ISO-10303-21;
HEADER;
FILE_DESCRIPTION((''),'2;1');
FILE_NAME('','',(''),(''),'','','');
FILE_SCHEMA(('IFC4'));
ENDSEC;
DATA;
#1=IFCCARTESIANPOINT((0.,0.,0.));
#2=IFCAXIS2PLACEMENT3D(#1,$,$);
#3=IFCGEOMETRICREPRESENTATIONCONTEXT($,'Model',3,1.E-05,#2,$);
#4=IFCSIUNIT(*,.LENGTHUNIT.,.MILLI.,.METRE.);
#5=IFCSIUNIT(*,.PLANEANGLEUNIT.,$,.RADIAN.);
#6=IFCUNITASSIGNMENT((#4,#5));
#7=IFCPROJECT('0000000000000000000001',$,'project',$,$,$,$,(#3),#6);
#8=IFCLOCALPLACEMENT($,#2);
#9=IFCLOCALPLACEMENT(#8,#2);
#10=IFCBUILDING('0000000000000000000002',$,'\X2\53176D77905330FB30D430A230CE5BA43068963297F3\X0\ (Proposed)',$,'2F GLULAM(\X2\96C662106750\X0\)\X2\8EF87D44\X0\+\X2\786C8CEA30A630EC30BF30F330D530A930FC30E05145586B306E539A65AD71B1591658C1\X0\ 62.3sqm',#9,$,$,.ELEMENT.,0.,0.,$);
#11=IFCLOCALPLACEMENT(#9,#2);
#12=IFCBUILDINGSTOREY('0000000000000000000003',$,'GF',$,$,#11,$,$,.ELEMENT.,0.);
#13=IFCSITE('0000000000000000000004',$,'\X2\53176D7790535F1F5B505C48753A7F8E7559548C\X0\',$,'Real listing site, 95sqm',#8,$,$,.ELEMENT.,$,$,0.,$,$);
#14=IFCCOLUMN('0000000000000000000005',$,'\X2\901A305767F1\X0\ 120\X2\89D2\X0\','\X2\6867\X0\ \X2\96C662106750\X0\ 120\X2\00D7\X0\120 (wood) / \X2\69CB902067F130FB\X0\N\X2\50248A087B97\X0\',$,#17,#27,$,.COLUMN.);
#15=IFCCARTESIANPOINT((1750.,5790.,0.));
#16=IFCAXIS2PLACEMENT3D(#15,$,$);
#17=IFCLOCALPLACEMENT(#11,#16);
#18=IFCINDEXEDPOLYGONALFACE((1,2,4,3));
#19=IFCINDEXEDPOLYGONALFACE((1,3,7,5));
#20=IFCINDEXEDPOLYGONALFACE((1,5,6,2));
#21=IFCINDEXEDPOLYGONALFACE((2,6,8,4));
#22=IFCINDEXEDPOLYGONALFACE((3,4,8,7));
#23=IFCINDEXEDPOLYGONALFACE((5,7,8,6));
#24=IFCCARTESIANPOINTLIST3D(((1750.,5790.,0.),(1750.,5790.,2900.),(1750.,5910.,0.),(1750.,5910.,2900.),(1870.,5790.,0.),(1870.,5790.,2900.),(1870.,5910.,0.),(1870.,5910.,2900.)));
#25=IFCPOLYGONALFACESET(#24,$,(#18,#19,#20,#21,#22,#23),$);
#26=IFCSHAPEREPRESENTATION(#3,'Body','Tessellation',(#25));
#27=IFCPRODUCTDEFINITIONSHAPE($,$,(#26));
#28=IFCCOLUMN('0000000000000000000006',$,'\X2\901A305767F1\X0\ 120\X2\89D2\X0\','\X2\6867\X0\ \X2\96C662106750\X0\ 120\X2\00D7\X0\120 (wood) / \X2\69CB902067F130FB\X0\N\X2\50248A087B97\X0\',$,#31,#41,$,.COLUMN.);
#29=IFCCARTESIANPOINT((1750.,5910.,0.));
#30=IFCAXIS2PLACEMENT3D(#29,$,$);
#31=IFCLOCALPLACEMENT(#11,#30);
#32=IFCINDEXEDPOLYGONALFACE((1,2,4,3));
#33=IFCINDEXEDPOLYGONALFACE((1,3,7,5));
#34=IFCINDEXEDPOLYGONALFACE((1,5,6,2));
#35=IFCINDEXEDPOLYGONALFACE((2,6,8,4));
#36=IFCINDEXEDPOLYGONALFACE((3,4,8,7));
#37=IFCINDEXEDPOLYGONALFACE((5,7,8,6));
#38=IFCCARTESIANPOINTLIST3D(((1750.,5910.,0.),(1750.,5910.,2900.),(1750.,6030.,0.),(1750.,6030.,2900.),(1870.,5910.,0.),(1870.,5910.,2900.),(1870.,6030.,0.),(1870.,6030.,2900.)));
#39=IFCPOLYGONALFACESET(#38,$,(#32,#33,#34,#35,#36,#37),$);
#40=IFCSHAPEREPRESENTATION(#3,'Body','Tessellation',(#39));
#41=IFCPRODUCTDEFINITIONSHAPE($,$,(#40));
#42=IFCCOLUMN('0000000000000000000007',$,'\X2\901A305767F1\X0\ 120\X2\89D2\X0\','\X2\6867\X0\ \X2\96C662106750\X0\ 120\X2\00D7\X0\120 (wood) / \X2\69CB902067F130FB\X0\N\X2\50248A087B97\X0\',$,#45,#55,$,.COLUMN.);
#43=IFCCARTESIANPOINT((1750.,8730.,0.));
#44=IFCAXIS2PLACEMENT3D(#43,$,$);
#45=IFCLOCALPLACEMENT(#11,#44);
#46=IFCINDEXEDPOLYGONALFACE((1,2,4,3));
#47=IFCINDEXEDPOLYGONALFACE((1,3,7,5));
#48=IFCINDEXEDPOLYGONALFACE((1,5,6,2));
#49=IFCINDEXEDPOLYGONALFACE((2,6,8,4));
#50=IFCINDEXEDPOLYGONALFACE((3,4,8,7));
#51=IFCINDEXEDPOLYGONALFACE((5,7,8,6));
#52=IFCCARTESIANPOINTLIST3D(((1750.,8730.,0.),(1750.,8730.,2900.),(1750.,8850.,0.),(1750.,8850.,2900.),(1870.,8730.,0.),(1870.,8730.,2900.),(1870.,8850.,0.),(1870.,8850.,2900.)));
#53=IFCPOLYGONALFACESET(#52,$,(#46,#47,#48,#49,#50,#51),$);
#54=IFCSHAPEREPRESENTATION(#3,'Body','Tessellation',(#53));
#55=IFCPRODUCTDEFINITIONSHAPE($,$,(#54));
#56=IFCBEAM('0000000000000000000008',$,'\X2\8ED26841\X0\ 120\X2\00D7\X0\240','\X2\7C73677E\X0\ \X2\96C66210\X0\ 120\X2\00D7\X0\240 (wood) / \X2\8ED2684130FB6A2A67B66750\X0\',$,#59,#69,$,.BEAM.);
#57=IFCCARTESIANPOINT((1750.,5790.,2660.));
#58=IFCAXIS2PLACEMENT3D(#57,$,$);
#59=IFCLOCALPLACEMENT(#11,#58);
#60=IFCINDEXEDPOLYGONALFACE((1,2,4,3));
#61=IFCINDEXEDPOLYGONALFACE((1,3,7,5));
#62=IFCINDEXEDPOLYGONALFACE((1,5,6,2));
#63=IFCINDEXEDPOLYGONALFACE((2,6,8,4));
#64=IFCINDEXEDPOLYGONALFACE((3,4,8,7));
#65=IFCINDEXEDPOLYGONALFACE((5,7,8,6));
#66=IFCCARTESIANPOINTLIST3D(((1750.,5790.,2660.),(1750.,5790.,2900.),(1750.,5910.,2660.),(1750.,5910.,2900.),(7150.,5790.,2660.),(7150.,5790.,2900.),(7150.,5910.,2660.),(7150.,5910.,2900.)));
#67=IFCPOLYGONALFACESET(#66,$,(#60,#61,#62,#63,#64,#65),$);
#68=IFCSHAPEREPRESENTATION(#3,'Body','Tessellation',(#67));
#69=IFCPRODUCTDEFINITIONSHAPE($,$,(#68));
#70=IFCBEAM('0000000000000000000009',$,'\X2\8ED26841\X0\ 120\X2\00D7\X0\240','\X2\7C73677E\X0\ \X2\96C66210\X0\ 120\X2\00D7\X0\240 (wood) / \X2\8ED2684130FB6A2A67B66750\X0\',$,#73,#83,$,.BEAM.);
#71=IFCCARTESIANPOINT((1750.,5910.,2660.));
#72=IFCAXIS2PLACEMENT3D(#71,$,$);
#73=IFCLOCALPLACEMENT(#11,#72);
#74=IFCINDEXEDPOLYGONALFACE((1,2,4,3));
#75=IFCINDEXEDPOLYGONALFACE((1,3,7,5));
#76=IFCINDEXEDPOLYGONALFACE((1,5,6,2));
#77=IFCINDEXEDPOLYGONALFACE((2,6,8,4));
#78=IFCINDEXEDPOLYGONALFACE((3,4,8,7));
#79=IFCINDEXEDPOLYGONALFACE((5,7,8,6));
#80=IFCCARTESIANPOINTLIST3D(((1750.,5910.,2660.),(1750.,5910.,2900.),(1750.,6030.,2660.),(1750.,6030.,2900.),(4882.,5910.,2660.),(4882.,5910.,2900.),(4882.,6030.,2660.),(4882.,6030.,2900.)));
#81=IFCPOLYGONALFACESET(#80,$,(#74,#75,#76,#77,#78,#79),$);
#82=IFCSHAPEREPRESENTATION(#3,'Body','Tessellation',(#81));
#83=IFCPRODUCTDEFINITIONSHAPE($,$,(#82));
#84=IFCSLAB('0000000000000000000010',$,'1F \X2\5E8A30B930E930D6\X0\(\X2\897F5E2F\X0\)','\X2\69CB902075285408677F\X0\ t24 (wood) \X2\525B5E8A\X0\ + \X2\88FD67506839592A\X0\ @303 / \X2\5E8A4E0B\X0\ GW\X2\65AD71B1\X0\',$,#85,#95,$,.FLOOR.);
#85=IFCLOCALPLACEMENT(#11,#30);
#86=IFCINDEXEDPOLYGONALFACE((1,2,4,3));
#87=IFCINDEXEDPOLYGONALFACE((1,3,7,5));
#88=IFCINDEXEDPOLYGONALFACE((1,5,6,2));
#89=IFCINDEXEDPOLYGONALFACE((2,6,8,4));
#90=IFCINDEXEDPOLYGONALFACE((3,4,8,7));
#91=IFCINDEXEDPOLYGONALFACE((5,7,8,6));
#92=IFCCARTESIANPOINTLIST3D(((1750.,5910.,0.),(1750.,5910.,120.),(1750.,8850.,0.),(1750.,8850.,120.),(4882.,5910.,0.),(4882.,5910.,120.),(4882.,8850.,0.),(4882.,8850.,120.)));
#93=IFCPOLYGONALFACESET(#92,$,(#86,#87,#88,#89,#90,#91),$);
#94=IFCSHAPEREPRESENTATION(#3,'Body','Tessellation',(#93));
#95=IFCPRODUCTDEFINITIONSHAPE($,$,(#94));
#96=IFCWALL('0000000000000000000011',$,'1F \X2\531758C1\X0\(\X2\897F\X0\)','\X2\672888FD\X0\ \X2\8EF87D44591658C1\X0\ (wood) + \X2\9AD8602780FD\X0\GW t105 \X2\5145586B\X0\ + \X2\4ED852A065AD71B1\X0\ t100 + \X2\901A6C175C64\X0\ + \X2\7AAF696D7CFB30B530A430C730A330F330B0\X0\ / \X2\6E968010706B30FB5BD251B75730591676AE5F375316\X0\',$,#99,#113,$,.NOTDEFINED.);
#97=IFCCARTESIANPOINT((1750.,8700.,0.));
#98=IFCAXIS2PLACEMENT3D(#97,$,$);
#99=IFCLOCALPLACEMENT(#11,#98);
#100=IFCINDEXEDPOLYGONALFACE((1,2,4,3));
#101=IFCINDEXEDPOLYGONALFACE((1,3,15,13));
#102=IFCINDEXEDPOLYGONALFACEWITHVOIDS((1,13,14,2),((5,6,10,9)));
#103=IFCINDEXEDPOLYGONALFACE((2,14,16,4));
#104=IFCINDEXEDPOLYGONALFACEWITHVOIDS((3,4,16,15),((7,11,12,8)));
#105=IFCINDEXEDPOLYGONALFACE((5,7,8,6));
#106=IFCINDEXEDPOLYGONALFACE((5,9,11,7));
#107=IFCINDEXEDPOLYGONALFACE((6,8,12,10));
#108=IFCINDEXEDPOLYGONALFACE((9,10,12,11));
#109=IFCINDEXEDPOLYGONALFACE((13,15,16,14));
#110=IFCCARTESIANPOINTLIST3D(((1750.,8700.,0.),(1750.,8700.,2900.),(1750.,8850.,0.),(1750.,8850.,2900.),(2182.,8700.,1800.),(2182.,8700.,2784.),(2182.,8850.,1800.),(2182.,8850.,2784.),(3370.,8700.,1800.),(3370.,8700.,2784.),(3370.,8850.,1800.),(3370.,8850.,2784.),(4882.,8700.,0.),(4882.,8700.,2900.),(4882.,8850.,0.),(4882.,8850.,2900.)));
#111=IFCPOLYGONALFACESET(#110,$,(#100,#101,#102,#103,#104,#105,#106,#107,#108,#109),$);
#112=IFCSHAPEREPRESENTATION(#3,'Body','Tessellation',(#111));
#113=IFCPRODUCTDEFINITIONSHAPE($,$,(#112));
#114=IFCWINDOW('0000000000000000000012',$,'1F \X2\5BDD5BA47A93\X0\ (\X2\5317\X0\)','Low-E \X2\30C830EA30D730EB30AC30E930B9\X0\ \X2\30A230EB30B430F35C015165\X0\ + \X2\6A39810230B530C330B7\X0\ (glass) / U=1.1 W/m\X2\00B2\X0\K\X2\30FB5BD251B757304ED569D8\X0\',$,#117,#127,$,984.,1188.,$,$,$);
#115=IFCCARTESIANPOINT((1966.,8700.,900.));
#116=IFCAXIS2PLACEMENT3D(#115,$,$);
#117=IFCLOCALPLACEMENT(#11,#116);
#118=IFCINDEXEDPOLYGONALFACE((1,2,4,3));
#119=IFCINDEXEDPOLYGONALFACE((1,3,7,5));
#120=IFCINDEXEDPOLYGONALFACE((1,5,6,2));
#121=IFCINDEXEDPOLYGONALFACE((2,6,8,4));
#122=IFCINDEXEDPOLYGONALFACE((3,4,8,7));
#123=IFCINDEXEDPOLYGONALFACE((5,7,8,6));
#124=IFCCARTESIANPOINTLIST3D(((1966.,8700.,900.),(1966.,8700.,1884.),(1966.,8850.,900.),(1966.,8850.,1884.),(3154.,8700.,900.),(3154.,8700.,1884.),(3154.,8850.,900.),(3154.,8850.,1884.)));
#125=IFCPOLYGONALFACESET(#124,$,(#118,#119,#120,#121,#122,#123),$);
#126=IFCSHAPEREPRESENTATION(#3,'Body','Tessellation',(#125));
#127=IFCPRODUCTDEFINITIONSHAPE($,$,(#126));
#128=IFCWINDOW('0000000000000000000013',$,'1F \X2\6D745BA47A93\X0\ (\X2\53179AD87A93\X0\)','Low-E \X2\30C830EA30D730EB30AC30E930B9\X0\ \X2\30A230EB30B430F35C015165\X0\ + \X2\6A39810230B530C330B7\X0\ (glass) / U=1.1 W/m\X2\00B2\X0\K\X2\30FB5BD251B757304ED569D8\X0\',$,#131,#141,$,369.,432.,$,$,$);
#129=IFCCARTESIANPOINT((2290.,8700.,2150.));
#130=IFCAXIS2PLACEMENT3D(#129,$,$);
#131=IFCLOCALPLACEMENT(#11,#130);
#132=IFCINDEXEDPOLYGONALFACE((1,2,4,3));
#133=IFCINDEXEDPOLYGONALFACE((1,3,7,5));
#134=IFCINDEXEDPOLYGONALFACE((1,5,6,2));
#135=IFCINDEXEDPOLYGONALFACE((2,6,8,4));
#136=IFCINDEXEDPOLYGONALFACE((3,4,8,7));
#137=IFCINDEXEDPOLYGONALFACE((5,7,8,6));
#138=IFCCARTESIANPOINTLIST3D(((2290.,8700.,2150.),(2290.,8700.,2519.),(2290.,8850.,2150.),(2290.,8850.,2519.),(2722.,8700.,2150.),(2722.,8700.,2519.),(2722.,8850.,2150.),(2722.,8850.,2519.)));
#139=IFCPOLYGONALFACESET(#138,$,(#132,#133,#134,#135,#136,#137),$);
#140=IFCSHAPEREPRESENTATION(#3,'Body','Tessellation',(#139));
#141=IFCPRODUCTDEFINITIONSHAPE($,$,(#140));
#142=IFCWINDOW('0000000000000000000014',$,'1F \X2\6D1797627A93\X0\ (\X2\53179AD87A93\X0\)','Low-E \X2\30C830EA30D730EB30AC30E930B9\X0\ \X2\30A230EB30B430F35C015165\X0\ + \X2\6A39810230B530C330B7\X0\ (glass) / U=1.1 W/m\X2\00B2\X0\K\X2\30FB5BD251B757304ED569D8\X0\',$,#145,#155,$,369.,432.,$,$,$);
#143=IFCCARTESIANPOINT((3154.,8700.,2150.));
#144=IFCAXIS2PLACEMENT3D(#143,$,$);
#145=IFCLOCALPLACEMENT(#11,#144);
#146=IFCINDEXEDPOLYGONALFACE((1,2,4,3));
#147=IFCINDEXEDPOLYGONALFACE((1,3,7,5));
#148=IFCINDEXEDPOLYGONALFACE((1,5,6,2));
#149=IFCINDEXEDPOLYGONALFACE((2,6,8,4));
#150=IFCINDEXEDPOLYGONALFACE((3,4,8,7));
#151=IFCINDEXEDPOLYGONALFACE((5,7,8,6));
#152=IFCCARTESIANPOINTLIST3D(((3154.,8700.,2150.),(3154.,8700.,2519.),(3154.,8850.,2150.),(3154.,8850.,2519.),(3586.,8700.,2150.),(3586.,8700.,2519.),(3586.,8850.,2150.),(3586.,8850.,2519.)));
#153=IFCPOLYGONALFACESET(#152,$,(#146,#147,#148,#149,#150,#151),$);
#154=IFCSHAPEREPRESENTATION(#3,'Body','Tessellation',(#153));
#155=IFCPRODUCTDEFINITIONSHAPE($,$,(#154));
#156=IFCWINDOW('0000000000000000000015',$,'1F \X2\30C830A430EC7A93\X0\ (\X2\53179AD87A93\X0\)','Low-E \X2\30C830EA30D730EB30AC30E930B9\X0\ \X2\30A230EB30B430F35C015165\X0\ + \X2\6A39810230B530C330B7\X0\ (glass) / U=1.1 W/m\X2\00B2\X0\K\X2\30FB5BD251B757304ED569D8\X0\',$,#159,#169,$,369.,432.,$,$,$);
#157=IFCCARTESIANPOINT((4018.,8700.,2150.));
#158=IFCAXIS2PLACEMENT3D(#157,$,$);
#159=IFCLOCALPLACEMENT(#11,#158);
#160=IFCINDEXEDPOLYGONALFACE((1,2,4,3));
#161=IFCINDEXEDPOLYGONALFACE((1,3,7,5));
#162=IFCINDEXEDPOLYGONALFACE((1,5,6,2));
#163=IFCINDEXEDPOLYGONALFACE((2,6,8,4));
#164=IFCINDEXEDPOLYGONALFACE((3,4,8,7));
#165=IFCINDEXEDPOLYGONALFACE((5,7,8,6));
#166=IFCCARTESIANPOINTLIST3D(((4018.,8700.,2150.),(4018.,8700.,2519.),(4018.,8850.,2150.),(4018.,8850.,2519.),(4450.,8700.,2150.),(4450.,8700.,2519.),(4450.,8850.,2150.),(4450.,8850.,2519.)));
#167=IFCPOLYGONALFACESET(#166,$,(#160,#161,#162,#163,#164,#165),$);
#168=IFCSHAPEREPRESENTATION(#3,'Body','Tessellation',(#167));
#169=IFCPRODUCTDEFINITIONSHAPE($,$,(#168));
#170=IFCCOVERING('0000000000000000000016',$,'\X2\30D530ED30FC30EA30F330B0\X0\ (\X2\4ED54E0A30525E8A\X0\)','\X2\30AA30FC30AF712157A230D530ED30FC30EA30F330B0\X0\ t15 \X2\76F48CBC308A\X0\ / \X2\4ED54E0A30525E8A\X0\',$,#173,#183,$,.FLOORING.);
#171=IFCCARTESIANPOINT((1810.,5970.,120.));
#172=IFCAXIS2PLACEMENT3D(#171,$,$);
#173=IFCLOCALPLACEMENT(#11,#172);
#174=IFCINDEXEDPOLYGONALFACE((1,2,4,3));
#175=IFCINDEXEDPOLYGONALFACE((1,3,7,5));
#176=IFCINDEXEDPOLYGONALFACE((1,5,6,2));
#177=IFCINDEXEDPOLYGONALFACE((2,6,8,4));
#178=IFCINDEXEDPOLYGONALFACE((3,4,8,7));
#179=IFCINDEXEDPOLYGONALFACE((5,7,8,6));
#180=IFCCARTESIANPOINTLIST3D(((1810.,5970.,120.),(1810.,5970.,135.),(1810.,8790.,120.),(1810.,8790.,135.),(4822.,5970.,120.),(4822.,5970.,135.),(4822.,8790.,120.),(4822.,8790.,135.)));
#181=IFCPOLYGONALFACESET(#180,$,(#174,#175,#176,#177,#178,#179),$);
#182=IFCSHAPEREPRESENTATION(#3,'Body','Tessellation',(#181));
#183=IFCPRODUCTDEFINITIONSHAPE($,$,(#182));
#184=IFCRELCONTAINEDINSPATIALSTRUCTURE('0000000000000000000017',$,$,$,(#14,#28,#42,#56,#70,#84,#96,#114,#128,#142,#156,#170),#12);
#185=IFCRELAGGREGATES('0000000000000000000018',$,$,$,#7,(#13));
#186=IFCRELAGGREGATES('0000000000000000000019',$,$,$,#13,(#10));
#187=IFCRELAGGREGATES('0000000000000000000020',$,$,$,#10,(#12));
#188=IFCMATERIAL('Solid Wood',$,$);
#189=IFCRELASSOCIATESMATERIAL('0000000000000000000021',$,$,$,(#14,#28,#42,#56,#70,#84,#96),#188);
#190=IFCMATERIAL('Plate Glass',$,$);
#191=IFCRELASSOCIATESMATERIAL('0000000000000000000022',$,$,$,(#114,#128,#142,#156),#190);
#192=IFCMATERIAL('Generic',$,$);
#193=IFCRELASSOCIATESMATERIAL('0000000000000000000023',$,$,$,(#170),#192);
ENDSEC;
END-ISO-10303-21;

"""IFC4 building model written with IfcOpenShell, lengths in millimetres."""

from ifc_helpers import new_model, si_unit, frame, frame_2d, origin, place, context, project, spatial, rectangle, extrude, material, element, fill, save


model = new_model("IFC4")

# Units and contexts
model_context = context("Model", 3, precision=1e-05, world=origin())
ifc_project = project(units=[si_unit("LENGTHUNIT", "METRE", prefix="MILLI"), si_unit("PLANEANGLEUNIT", "RADIAN")], contexts=[model_context])

# Site, building, storey
site_placement = place(None, origin())
site = spatial("IfcSite", under=ifc_project, at=site_placement, Name="北海道弟子屈町美留和", ObjectType="Real listing site, 95sqm", CompositionType="ELEMENT", RefElevation=0.0)
building_placement = place(site_placement, origin())
building = spatial("IfcBuilding", under=site, at=building_placement, Name="北海道・ピアノ室と防音 (Proposed)", ObjectType="2F GLULAM(集成材)軸組+硬質ウレタンフォーム充填の厚断熱外壁 62.3sqm", CompositionType="ELEMENT", ElevationOfRefHeight=0.0, ElevationOfTerrain=0.0)
storey_placement = place(building_placement, origin())
storey = spatial("IfcBuildingStorey", under=building, at=storey_placement, Name="GF", CompositionType="ELEMENT", Elevation=0.0)

# Columns
ifc_material_1 = material(Name="Solid Wood")
column_1_placement = place(storey_placement, frame((1750.0, 5790.0, 0.0)))
element("IfcColumn", 1, at=column_1_placement, inside=storey, material=ifc_material_1, Name="通し柱 120角", Description="桧 集成材 120×120 (wood) / 構造柱・N値計算", PredefinedType="COLUMN", context=model_context, shape_type="SweptSolid", body=[
    extrude(rectangle(XDim=120.0, YDim=120.0, at=frame_2d((60.0, 60.0))), frame((1750.0, 5790.0, 0.0)), (0.0, 0.0, 1.0), 2900.0),
])
column_2_placement = place(storey_placement, frame((1750.0, 5910.0, 0.0)))
element("IfcColumn", 2, at=column_2_placement, inside=storey, material=ifc_material_1, Name="通し柱 120角", Description="桧 集成材 120×120 (wood) / 構造柱・N値計算", PredefinedType="COLUMN", context=model_context, shape_type="SweptSolid", body=[
    extrude(rectangle(XDim=120.0, YDim=120.0, at=frame_2d((60.0, 60.0))), frame((1750.0, 5910.0, 0.0)), (0.0, 0.0, 1.0), 2900.0),
])
column_3_placement = place(storey_placement, frame((1750.0, 8730.0, 0.0)))
element("IfcColumn", 3, at=column_3_placement, inside=storey, material=ifc_material_1, Name="通し柱 120角", Description="桧 集成材 120×120 (wood) / 構造柱・N値計算", PredefinedType="COLUMN", context=model_context, shape_type="SweptSolid", body=[
    extrude(rectangle(XDim=120.0, YDim=120.0, at=frame_2d((60.0, 60.0))), frame((1750.0, 8730.0, 0.0)), (0.0, 0.0, 1.0), 2900.0),
])

# Beams
beam_1_placement = place(storey_placement, frame((1750.0, 5790.0, 2660.0)))
element("IfcBeam", 4, at=beam_1_placement, inside=storey, material=ifc_material_1, Name="軒桁 120×240", Description="米松 集成 120×240 (wood) / 軒桁・横架材", PredefinedType="BEAM", context=model_context, shape_type="SweptSolid", body=[
    extrude(rectangle(XDim=5400.0, YDim=120.0, at=frame_2d((2700.0, 60.0))), frame((1750.0, 5790.0, 2660.0)), (0.0, 0.0, 1.0), 240.0),
])
beam_2_placement = place(storey_placement, frame((1750.0, 5910.0, 2660.0)))
element("IfcBeam", 5, at=beam_2_placement, inside=storey, material=ifc_material_1, Name="軒桁 120×240", Description="米松 集成 120×240 (wood) / 軒桁・横架材", PredefinedType="BEAM", context=model_context, shape_type="SweptSolid", body=[
    extrude(rectangle(XDim=3132.0, YDim=120.0, at=frame_2d((1566.0, 60.0))), frame((1750.0, 5910.0, 2660.0)), (0.0, 0.0, 1.0), 240.0),
])

# Slab
slab_placement = place(storey_placement, frame((1750.0, 5910.0, 0.0)))
element("IfcSlab", 6, at=slab_placement, inside=storey, material=ifc_material_1, Name="1F 床スラブ(西帯)", Description="構造用合板 t24 (wood) 剛床 + 製材根太 @303 / 床下 GW断熱", PredefinedType="FLOOR", context=model_context, shape_type="SweptSolid", body=[
    extrude(rectangle(XDim=3132.0, YDim=2940.0, at=frame_2d((1566.0, 1470.0))), frame((1750.0, 5910.0, 0.0)), (0.0, 0.0, 1.0), 120.0),
])

# Wall, openings, windows
wall_1_placement = place(storey_placement, frame((1750.0, 8700.0, 0.0)))
wall_1 = element("IfcWall", 7, at=wall_1_placement, inside=storey, material=ifc_material_1, Name="1F 北壁(西)", Description="木製 軸組外壁 (wood) + 高性能GW t105 充填 + 付加断熱 t100 + 通気層 + 窯業系サイディング / 準耐火・寒冷地外皮強化", PredefinedType="NOTDEFINED", context=model_context, shape_type="SweptSolid", body=[
    extrude(rectangle(XDim=3132.0, YDim=150.0, at=frame_2d((1566.0, 75.0))), frame((1750.0, 8700.0, 0.0)), (0.0, 0.0, 1.0), 2900.0),
])
opening_1_placement = place(storey_placement, frame((1966.0, 8700.0, 900.0)))
opening_1 = element("IfcOpeningElement", 8, at=opening_1_placement, cuts=wall_1, PredefinedType="NOTDEFINED", context=model_context, shape_type="SweptSolid", body=[
    extrude(rectangle(XDim=1188.0, YDim=150.0, at=frame_2d((594.0, 75.0))), frame((1966.0, 8700.0, 900.0)), (0.0, 0.0, 1.0), 984.0),
])
opening_2_placement = place(storey_placement, frame((2290.0, 8700.0, 2150.0)))
opening_2 = element("IfcOpeningElement", 9, at=opening_2_placement, cuts=wall_1, PredefinedType="NOTDEFINED", context=model_context, shape_type="SweptSolid", body=[
    extrude(rectangle(XDim=432.0, YDim=150.0, at=frame_2d((216.0, 75.0))), frame((2290.0, 8700.0, 2150.0)), (0.0, 0.0, 1.0), 369.0),
])
opening_3_placement = place(storey_placement, frame((3154.0, 8700.0, 2150.0)))
opening_3 = element("IfcOpeningElement", 10, at=opening_3_placement, cuts=wall_1, PredefinedType="NOTDEFINED", context=model_context, shape_type="SweptSolid", body=[
    extrude(rectangle(XDim=432.0, YDim=150.0, at=frame_2d((216.0, 75.0))), frame((3154.0, 8700.0, 2150.0)), (0.0, 0.0, 1.0), 369.0),
])
opening_4_placement = place(storey_placement, frame((4018.0, 8700.0, 2150.0)))
opening_4 = element("IfcOpeningElement", 11, at=opening_4_placement, cuts=wall_1, PredefinedType="NOTDEFINED", context=model_context, shape_type="SweptSolid", body=[
    extrude(rectangle(XDim=432.0, YDim=150.0, at=frame_2d((216.0, 75.0))), frame((4018.0, 8700.0, 2150.0)), (0.0, 0.0, 1.0), 369.0),
])
ifc_material_2 = material(Name="Plate Glass")
window_1_placement = place(storey_placement, frame((1966.0, 8700.0, 900.0)))
window_1 = element("IfcWindow", 12, at=window_1_placement, inside=storey, material=ifc_material_2, Name="1F 寝室窓 (北)", Description="Low-E トリプルガラス アルゴン封入 + 樹脂サッシ (glass) / U=1.1 W/m²K・寒冷地仕様", OverallHeight=984.0, OverallWidth=1188.0, context=model_context, shape_type="SweptSolid", body=[
    extrude(rectangle(XDim=1188.0, YDim=150.0, at=frame_2d((594.0, 75.0))), frame((1966.0, 8700.0, 900.0)), (0.0, 0.0, 1.0), 984.0),
])
fill(opening_1, window_1)
window_2_placement = place(storey_placement, frame((2290.0, 8700.0, 2150.0)))
window_2 = element("IfcWindow", 13, at=window_2_placement, inside=storey, material=ifc_material_2, Name="1F 浴室窓 (北高窓)", Description="Low-E トリプルガラス アルゴン封入 + 樹脂サッシ (glass) / U=1.1 W/m²K・寒冷地仕様", OverallHeight=369.0, OverallWidth=432.0, context=model_context, shape_type="SweptSolid", body=[
    extrude(rectangle(XDim=432.0, YDim=150.0, at=frame_2d((216.0, 75.0))), frame((2290.0, 8700.0, 2150.0)), (0.0, 0.0, 1.0), 369.0),
])
fill(opening_2, window_2)
window_3_placement = place(storey_placement, frame((3154.0, 8700.0, 2150.0)))
window_3 = element("IfcWindow", 14, at=window_3_placement, inside=storey, material=ifc_material_2, Name="1F 洗面窓 (北高窓)", Description="Low-E トリプルガラス アルゴン封入 + 樹脂サッシ (glass) / U=1.1 W/m²K・寒冷地仕様", OverallHeight=369.0, OverallWidth=432.0, context=model_context, shape_type="SweptSolid", body=[
    extrude(rectangle(XDim=432.0, YDim=150.0, at=frame_2d((216.0, 75.0))), frame((3154.0, 8700.0, 2150.0)), (0.0, 0.0, 1.0), 369.0),
])
fill(opening_3, window_3)
window_4_placement = place(storey_placement, frame((4018.0, 8700.0, 2150.0)))
window_4 = element("IfcWindow", 15, at=window_4_placement, inside=storey, material=ifc_material_2, Name="1F トイレ窓 (北高窓)", Description="Low-E トリプルガラス アルゴン封入 + 樹脂サッシ (glass) / U=1.1 W/m²K・寒冷地仕様", OverallHeight=369.0, OverallWidth=432.0, context=model_context, shape_type="SweptSolid", body=[
    extrude(rectangle(XDim=432.0, YDim=150.0, at=frame_2d((216.0, 75.0))), frame((4018.0, 8700.0, 2150.0)), (0.0, 0.0, 1.0), 369.0),
])
fill(opening_4, window_4)

# Covering
ifc_material_3 = material(Name="Generic")
covering_placement = place(storey_placement, frame((1810.0, 5970.0, 120.0)))
element("IfcCovering", 16, at=covering_placement, inside=storey, material=ifc_material_3, Name="フローリング (仕上げ床)", Description="オーク無垢フローリング t15 直貼り / 仕上げ床", PredefinedType="FLOORING", context=model_context, shape_type="SweptSolid", body=[
    extrude(rectangle(XDim=3012.0, YDim=2820.0, at=frame_2d((1506.0, 1410.0))), frame((1810.0, 5970.0, 120.0)), (0.0, 0.0, 1.0), 15.0),
])

save(model, "model.ifc")
